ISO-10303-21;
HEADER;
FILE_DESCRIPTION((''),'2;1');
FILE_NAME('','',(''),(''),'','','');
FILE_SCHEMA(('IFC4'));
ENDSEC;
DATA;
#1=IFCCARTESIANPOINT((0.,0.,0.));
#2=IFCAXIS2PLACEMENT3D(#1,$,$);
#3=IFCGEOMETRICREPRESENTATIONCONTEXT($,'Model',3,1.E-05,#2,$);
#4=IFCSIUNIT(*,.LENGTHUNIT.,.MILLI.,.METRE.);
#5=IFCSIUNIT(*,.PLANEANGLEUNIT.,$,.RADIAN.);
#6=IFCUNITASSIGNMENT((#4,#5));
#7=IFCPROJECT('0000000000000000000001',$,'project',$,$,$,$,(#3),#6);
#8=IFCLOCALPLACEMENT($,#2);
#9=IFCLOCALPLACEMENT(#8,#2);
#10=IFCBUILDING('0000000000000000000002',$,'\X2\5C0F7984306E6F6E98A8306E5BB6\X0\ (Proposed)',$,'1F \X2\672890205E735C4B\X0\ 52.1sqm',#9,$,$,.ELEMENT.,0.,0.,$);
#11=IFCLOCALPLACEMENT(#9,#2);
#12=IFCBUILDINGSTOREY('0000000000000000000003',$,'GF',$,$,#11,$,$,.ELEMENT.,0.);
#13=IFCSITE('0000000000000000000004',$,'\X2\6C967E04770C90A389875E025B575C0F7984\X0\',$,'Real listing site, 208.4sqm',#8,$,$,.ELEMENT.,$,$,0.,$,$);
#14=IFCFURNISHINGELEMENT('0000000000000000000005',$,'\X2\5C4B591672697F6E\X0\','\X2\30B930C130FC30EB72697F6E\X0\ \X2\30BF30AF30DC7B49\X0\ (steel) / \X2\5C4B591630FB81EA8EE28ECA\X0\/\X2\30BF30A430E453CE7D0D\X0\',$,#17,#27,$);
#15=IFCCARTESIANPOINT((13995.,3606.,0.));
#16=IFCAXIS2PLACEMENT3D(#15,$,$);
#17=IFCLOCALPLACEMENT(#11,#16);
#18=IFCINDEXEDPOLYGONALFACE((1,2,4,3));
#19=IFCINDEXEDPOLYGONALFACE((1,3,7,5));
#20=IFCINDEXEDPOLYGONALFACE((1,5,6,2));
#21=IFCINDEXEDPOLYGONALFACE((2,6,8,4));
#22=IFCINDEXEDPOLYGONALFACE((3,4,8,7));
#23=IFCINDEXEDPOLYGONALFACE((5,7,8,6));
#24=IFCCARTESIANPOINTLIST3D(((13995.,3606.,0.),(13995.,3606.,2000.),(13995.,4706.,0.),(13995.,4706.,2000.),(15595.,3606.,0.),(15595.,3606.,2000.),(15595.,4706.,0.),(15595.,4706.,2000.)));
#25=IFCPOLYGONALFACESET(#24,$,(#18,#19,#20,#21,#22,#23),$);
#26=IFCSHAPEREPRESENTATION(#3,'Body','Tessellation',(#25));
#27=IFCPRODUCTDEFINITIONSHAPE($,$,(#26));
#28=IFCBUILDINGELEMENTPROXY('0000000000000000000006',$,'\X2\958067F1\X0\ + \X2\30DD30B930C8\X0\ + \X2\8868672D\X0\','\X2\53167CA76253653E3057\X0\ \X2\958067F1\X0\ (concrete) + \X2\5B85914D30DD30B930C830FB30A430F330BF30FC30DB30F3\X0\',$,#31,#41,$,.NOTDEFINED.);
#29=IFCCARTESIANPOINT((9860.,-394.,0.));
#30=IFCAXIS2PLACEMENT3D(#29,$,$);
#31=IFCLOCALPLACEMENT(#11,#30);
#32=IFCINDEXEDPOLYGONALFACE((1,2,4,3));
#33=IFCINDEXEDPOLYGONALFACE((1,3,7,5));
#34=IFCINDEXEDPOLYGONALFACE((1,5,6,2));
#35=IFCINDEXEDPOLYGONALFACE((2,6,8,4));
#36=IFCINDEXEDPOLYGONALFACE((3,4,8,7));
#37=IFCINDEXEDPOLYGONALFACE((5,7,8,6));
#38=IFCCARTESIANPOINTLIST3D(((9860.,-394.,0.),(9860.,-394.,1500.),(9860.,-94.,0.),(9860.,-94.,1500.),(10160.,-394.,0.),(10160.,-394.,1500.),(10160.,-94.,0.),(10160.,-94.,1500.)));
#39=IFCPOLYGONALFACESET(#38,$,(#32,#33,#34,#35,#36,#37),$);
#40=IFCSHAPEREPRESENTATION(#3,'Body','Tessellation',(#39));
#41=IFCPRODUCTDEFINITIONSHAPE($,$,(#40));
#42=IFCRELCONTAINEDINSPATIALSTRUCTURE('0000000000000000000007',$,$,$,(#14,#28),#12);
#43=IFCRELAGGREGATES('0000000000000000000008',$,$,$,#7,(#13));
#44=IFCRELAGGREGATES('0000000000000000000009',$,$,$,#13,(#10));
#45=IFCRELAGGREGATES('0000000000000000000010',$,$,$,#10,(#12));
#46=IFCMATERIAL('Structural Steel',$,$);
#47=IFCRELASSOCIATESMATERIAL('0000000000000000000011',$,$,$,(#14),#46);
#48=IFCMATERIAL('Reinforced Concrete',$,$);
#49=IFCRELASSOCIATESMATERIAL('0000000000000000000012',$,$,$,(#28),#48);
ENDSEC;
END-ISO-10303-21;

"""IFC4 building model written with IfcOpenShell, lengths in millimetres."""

from ifc_helpers import new_model, si_unit, frame, frame_2d, origin, place, context, project, spatial, rectangle, extrude, material, element, save


model = new_model("IFC4")

# Units and contexts
model_context = context("Model", 3, precision=1e-05, world=origin())
ifc_project = project(units=[si_unit("LENGTHUNIT", "METRE", prefix="MILLI"), si_unit("PLANEANGLEUNIT", "RADIAN")], contexts=[model_context])

# Site, building, storey
site_placement = place(None, origin())
site = spatial("IfcSite", under=ifc_project, at=site_placement, Name="沖縄県那覇市字小禄", ObjectType="Real listing site, 208.4sqm", CompositionType="ELEMENT", RefElevation=0.0)
building_placement = place(site_placement, origin())
building = spatial("IfcBuilding", under=site, at=building_placement, Name="小禄の潮風の家 (Proposed)", ObjectType="1F 木造平屋 52.1sqm", CompositionType="ELEMENT", ElevationOfRefHeight=0.0, ElevationOfTerrain=0.0)
storey_placement = place(building_placement, origin())
storey = spatial("IfcBuildingStorey", under=building, at=storey_placement, Name="GF", CompositionType="ELEMENT", Elevation=0.0)

# Shared definitions
ifc_material_1 = material(Name="Reinforced Concrete")

# Shared definitions
ifc_material_2 = material(Name="Structural Steel")

# Furnishing element
furnishing_1_placement = place(storey_placement, frame((13995.0, 3606.0, 0.0)))
element("IfcFurnishingElement", 1, at=furnishing_1_placement, inside=storey, material=ifc_material_2, Name="屋外物置", Description="スチール物置 タクボ等 (steel) / 屋外・自転車/タイヤ収納", context=model_context, shape_type="SweptSolid", body=[
    extrude(rectangle(XDim=1600.0, YDim=1100.0, at=frame_2d((800.0, 550.0))), frame((13995.0, 3606.0, 0.0)), (0.0, 0.0, 1.0), 2000.0),
])

# Building element proxy
proxy_placement = place(storey_placement, frame((9860.0, -394.0, 0.0)))
element("IfcBuildingElementProxy", 2, at=proxy_placement, inside=storey, material=ifc_material_1, Name="門柱 + ポスト + 表札", Description="化粧打放し 門柱 (concrete) + 宅配ポスト・インターホン", PredefinedType="NOTDEFINED", context=model_context, shape_type="SweptSolid", body=[
    extrude(rectangle(XDim=300.0, YDim=300.0, at=frame_2d((150.0, 150.0))), frame((9860.0, -394.0, 0.0)), (0.0, 0.0, 1.0), 1500.0),
])

save(model, "model.ifc")
